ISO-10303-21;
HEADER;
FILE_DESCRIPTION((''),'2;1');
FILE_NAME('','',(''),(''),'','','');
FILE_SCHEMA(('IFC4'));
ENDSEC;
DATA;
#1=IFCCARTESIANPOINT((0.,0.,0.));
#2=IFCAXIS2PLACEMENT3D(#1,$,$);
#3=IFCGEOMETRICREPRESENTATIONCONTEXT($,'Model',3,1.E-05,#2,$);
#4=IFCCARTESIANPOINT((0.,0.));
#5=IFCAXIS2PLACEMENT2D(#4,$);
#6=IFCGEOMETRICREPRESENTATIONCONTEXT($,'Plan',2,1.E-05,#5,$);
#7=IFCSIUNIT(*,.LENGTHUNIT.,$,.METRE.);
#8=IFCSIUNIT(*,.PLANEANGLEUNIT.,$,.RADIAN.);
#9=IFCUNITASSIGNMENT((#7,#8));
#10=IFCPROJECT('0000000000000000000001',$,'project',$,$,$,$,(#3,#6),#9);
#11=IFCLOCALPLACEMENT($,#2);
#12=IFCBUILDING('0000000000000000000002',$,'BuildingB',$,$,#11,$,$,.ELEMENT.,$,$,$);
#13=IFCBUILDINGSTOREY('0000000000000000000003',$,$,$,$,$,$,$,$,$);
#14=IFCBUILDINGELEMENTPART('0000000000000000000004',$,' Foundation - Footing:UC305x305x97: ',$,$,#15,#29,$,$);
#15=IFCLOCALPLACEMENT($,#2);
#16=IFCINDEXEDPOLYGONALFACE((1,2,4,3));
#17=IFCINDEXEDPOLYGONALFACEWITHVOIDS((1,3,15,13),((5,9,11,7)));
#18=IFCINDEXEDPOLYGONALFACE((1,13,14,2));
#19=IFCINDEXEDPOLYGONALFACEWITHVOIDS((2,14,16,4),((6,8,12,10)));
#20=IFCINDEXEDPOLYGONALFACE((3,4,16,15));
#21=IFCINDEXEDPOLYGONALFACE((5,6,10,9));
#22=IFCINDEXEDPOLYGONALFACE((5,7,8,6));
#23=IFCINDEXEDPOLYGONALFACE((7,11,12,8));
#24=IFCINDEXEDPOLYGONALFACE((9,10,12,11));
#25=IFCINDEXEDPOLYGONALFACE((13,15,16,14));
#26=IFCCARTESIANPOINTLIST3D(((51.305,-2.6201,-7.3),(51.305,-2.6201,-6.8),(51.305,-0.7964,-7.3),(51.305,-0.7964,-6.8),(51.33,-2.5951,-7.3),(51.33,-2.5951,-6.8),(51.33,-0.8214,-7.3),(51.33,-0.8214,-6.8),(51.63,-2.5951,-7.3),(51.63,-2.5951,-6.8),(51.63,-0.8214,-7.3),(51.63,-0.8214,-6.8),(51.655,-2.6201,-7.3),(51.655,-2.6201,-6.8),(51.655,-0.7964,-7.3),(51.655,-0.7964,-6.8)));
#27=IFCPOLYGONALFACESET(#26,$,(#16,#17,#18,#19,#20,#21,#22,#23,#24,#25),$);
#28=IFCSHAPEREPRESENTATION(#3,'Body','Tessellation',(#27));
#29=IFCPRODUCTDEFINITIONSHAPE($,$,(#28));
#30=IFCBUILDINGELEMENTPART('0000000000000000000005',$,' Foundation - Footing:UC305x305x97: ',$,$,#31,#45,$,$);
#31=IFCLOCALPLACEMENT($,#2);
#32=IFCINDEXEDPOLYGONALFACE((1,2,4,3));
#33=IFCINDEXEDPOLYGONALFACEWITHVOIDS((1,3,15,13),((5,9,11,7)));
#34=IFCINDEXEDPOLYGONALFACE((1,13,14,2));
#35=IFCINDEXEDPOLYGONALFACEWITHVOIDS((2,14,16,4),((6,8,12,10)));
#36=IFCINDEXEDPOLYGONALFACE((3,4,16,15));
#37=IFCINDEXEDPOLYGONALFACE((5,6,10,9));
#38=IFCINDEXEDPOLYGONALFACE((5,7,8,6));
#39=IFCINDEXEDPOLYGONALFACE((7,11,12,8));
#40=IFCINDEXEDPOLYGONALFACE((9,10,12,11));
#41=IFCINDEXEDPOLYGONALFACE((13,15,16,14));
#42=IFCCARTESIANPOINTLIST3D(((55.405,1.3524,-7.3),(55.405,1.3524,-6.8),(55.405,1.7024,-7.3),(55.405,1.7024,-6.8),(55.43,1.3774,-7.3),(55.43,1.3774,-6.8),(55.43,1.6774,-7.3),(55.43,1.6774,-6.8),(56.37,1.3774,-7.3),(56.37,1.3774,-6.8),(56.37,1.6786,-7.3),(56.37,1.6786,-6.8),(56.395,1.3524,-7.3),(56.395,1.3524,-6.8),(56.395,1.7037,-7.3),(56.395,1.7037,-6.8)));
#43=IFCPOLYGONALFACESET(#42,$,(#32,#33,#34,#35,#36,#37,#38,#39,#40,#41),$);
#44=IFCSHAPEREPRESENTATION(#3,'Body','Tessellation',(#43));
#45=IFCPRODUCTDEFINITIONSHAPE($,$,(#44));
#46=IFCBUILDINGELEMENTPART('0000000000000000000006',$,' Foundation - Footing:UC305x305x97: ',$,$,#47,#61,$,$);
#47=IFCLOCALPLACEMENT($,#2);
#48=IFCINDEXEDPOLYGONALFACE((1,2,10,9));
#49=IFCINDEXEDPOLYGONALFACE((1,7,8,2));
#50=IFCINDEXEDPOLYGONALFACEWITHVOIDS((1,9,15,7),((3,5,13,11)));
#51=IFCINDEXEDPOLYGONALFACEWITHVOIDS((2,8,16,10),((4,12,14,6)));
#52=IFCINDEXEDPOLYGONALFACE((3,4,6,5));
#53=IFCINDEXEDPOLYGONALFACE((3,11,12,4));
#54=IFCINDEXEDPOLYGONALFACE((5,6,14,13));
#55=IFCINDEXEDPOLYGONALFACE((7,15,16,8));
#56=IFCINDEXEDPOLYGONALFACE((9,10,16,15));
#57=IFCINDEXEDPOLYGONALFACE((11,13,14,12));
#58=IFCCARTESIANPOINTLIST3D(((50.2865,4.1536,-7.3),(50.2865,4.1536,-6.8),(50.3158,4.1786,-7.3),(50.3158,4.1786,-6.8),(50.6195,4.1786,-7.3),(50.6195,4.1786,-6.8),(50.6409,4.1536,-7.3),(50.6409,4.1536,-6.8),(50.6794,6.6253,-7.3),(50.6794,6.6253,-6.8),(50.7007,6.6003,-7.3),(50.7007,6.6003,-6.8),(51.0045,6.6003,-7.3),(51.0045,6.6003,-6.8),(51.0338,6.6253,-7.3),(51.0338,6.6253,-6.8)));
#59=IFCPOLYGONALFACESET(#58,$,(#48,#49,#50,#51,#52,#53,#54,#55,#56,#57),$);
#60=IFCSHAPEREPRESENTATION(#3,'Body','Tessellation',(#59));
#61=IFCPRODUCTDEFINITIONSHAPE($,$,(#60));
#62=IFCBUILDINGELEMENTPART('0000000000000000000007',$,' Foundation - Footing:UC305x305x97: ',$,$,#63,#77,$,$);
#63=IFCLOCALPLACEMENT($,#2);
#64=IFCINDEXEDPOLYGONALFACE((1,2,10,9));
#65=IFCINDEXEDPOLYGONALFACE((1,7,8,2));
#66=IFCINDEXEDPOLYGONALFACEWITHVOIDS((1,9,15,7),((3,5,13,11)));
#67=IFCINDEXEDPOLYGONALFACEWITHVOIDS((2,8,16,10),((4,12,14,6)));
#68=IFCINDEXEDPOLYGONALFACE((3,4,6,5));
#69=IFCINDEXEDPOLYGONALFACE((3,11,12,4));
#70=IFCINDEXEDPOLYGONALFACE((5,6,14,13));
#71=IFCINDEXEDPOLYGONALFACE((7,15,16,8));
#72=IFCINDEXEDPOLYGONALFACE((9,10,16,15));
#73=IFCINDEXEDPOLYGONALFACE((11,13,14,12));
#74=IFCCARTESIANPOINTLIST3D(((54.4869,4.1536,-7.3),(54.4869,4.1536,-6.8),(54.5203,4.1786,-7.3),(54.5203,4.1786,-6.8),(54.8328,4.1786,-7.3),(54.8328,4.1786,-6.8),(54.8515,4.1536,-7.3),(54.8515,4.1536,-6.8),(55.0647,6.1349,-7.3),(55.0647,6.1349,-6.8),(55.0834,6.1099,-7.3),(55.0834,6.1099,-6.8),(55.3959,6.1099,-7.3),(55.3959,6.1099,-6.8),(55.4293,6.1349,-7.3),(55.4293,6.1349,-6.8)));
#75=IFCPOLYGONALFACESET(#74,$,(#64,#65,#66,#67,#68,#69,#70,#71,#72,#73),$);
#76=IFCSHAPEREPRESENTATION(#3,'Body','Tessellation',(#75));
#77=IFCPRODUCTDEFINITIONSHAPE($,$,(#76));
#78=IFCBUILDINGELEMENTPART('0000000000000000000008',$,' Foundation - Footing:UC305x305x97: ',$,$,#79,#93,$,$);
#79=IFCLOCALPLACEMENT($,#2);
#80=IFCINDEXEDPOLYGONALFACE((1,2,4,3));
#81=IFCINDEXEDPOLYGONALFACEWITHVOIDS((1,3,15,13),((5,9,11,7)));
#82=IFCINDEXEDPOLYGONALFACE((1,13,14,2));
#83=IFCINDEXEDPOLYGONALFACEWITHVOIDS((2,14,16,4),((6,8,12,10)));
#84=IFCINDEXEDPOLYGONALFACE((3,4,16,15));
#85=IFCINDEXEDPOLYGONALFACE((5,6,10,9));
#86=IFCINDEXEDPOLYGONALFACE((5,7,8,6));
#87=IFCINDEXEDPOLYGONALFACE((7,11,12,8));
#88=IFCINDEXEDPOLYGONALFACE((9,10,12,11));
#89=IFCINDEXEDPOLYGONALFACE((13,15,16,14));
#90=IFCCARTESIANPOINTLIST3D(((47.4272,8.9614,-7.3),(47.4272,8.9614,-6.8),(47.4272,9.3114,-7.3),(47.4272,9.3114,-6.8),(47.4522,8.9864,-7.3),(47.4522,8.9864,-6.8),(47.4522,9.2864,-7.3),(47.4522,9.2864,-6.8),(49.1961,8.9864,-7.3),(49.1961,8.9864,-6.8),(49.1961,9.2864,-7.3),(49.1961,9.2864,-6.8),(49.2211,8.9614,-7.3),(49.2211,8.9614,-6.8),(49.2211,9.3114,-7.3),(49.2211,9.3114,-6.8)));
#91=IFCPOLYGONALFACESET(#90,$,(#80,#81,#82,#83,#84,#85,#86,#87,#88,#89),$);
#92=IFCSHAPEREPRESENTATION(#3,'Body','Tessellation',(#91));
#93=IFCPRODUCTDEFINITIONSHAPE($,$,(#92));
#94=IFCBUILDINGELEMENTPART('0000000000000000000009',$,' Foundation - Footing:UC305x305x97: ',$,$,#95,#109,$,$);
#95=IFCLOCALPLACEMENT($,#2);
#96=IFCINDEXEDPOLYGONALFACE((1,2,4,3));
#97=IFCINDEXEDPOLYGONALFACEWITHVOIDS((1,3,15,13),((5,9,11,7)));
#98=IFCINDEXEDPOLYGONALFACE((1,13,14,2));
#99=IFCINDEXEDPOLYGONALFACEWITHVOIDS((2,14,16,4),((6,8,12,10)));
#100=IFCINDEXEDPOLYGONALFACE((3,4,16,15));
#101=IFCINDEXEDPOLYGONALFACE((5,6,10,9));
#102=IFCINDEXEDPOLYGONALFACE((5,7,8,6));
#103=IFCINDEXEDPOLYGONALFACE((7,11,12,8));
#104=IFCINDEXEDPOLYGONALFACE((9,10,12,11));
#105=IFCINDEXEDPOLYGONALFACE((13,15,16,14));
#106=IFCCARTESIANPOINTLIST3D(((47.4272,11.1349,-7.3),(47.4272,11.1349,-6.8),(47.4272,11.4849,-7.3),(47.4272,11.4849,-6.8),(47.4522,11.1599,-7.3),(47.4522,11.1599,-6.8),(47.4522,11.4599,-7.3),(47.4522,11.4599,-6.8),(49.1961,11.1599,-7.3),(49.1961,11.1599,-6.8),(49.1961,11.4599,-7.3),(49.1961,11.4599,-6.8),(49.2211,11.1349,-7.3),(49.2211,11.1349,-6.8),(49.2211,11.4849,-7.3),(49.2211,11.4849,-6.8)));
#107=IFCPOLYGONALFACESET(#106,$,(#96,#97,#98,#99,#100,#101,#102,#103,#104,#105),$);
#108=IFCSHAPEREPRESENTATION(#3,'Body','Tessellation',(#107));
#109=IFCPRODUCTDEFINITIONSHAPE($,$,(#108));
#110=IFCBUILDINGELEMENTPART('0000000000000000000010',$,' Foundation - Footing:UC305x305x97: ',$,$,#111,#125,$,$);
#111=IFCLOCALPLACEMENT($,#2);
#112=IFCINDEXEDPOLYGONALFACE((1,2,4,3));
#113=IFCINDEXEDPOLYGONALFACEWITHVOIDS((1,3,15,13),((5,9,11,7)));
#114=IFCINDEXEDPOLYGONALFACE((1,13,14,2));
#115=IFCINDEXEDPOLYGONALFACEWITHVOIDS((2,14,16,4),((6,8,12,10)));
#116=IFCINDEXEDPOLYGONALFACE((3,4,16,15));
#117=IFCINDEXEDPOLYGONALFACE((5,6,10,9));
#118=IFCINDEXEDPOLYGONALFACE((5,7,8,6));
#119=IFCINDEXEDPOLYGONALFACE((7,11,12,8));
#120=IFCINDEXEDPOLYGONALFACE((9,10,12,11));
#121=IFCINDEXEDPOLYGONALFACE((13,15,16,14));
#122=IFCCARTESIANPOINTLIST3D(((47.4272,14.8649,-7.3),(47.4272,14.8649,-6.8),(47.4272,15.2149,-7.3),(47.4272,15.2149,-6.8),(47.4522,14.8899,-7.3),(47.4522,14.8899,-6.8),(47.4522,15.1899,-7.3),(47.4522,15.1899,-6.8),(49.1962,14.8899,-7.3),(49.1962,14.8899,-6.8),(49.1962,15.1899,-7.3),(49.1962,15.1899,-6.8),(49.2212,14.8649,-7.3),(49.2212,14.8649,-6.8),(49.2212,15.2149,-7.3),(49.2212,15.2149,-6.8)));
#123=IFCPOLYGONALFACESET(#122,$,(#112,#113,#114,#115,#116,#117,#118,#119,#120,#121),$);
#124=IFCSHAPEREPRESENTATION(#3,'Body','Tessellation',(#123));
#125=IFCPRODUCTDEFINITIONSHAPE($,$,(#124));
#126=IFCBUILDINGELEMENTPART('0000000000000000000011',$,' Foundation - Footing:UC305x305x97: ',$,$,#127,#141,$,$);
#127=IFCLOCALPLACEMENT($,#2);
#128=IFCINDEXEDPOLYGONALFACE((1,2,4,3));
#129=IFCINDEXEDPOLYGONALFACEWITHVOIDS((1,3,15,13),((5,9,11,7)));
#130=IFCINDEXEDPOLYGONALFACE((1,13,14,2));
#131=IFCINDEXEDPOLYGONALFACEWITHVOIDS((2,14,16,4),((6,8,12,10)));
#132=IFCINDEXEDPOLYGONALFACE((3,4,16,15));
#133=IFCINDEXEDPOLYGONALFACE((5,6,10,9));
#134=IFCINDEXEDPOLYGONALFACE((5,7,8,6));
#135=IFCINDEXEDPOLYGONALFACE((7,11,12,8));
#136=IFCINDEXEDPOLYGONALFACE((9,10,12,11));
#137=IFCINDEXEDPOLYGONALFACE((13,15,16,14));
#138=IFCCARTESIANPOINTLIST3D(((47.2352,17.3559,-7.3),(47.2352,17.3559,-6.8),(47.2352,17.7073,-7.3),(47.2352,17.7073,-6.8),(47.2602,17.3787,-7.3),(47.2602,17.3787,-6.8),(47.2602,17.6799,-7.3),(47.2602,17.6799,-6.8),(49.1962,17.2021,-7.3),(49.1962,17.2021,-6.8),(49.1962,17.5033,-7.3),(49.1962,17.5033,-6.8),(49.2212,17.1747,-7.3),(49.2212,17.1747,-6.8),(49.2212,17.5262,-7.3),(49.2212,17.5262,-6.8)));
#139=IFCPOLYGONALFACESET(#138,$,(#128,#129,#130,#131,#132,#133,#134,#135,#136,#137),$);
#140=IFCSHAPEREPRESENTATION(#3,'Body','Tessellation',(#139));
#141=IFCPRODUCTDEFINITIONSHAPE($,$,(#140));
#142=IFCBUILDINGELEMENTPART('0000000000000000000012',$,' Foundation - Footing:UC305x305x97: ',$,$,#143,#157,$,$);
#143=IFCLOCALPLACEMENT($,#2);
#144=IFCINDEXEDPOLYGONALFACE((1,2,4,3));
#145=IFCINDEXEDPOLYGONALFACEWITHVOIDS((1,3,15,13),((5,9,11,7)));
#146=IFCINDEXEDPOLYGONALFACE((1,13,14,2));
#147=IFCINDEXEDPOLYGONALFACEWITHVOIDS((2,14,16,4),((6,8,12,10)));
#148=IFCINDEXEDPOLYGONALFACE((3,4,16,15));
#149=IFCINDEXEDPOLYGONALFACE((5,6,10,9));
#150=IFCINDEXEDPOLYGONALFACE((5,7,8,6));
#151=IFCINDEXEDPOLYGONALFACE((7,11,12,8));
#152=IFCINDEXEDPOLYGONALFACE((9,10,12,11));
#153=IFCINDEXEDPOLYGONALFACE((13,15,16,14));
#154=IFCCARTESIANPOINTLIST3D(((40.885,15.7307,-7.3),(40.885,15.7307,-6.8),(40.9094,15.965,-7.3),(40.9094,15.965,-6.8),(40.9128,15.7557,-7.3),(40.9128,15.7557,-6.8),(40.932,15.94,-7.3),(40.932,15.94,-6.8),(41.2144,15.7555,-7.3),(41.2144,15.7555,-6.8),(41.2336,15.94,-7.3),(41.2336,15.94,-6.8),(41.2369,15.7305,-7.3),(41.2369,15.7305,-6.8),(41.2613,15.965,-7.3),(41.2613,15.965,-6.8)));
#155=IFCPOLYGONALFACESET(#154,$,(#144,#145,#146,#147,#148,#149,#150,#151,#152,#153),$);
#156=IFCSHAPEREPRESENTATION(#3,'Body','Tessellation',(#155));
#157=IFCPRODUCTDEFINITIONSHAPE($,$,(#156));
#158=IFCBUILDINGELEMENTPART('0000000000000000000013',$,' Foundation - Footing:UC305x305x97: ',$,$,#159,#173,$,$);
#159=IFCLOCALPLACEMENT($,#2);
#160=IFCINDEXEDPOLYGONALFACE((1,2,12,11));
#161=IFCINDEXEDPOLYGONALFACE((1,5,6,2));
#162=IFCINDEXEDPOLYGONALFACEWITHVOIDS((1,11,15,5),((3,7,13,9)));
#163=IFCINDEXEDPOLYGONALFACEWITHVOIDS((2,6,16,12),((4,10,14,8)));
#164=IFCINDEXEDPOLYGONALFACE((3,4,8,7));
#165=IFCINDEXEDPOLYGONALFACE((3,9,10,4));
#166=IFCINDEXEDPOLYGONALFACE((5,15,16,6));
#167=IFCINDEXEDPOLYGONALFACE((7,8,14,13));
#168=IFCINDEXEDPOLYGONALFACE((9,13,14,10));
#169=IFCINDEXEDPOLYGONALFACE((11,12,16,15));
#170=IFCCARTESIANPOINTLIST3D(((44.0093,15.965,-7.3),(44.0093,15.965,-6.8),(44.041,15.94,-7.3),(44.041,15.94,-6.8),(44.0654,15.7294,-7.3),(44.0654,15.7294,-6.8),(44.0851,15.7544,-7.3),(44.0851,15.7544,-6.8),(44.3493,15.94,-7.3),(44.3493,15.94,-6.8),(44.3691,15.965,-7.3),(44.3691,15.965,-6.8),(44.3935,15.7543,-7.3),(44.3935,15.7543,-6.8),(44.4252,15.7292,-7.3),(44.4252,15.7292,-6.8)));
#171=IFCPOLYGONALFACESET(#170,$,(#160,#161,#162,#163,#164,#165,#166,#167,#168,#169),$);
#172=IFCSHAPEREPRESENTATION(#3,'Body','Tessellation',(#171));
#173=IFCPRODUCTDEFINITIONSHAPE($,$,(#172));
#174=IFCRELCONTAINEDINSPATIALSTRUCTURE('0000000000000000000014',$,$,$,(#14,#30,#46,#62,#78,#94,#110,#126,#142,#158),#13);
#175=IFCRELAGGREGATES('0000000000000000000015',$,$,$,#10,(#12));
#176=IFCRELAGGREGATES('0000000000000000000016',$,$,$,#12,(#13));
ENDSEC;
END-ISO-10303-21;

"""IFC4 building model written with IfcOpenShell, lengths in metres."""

from ifc_helpers import new_model, si_unit, origin, origin_2d, place, context, project, spatial, polyline, outline, extrude, element, save


model = new_model("IFC4")

# Units and contexts
model_context = context("Model", 3, precision=1e-05, world=origin())
plan_context = context("Plan", 2, precision=1e-05, world=origin_2d())
ifc_project = project(units=[si_unit("LENGTHUNIT", "METRE"), si_unit("PLANEANGLEUNIT", "RADIAN")], contexts=[model_context, plan_context])

# Building, storey
building_placement = place(None, origin())
building = spatial("IfcBuilding", under=ifc_project, at=building_placement, Name="BuildingB", CompositionType="ELEMENT")
storey = spatial("IfcBuildingStorey", under=building)

# Building element parts, openings
building_element_part_1 = element("IfcBuildingElementPart", 1, inside=storey, Name=" Foundation - Footing:UC305x305x97: ", context=model_context, shape_type="SweptSolid", body=[
    extrude(outline(polyline([(51.305, -2.6201, -7.3), (51.655, -2.6201, -7.3), (51.655, -0.7964, -7.3), (51.305, -0.7964, -7.3), (51.305, -2.6201, -7.3)])), None, (0.0, 0.0, 1.0), 0.5),
])
element("IfcOpeningElement", 2, inside=storey, cuts=building_element_part_1, context=model_context, shape_type="SweptSolid", body=[
    extrude(outline(polyline([(51.33, -2.5951, -7.3), (51.63, -2.5951, -7.3), (51.63, -0.8214, -7.3), (51.33, -0.8214, -7.3), (51.33, -2.5951, -7.3)])), None, (0.0, 0.0, 1.0), 0.5),
])
building_element_part_2 = element("IfcBuildingElementPart", 3, inside=storey, Name=" Foundation - Footing:UC305x305x97: ", context=model_context, shape_type="SweptSolid", body=[
    extrude(outline(polyline([(55.405, 1.3524, -7.3), (55.405, 1.7024, -7.3), (56.395, 1.7037, -7.3), (56.395, 1.3524, -7.3), (55.405, 1.3524, -7.3)])), None, (0.0, 0.0, 1.0), 0.5),
])
element("IfcOpeningElement", 4, inside=storey, cuts=building_element_part_2, context=model_context, shape_type="SweptSolid", body=[
    extrude(outline(polyline([(55.43, 1.3774, -7.3), (55.43, 1.6774, -7.3), (56.37, 1.6786, -7.3), (56.37, 1.3774, -7.3), (55.43, 1.3774, -7.3)])), None, (0.0, 0.0, 1.0), 0.5),
])
building_element_part_3 = element("IfcBuildingElementPart", 5, inside=storey, Name=" Foundation - Footing:UC305x305x97: ", context=model_context, shape_type="SweptSolid", body=[
    extrude(outline(polyline([(50.2865, 4.1536, -7.3), (50.6794, 6.6253, -7.3), (51.0338, 6.6253, -7.3), (50.6409, 4.1536, -7.3), (50.2865, 4.1536, -7.3)])), None, (0.0, 0.0, 1.0), 0.5),
])
element("IfcOpeningElement", 6, inside=storey, cuts=building_element_part_3, context=model_context, shape_type="SweptSolid", body=[
    extrude(outline(polyline([(50.3158, 4.1786, -7.3), (50.7007, 6.6003, -7.3), (51.0045, 6.6003, -7.3), (50.6195, 4.1786, -7.3), (50.3158, 4.1786, -7.3)])), None, (0.0, 0.0, 1.0), 0.5),
])
building_element_part_4 = element("IfcBuildingElementPart", 7, inside=storey, Name=" Foundation - Footing:UC305x305x97: ", context=model_context, shape_type="SweptSolid", body=[
    extrude(outline(polyline([(54.8515, 4.1536, -7.3), (54.4869, 4.1536, -7.3), (55.0647, 6.1349, -7.3), (55.4293, 6.1349, -7.3), (54.8515, 4.1536, -7.3)])), None, (0.0, 0.0, 1.0), 0.5),
])
element("IfcOpeningElement", 8, inside=storey, cuts=building_element_part_4, context=model_context, shape_type="SweptSolid", body=[
    extrude(outline(polyline([(54.8328, 4.1786, -7.3), (54.5203, 4.1786, -7.3), (55.0834, 6.1099, -7.3), (55.3959, 6.1099, -7.3), (54.8328, 4.1786, -7.3)])), None, (0.0, 0.0, 1.0), 0.5),
])
building_element_part_5 = element("IfcBuildingElementPart", 9, inside=storey, Name=" Foundation - Footing:UC305x305x97: ", context=model_context, shape_type="SweptSolid", body=[
    extrude(outline(polyline([(47.4272, 8.9614, -7.3), (49.2211, 8.9614, -7.3), (49.2211, 9.3114, -7.3), (47.4272, 9.3114, -7.3), (47.4272, 8.9614, -7.3)])), None, (0.0, 0.0, 1.0), 0.5),
])
element("IfcOpeningElement", 10, inside=storey, cuts=building_element_part_5, context=model_context, shape_type="SweptSolid", body=[
    extrude(outline(polyline([(47.4522, 8.9864, -7.3), (49.1961, 8.9864, -7.3), (49.1961, 9.2864, -7.3), (47.4522, 9.2864, -7.3), (47.4522, 8.9864, -7.3)])), None, (0.0, 0.0, 1.0), 0.5),
])
building_element_part_6 = element("IfcBuildingElementPart", 11, inside=storey, Name=" Foundation - Footing:UC305x305x97: ", context=model_context, shape_type="SweptSolid", body=[
    extrude(outline(polyline([(47.4272, 11.1349, -7.3), (47.4272, 11.4849, -7.3), (49.2211, 11.4849, -7.3), (49.2211, 11.1349, -7.3), (47.4272, 11.1349, -7.3)])), None, (0.0, 0.0, 1.0), 0.5),
])
element("IfcOpeningElement", 12, inside=storey, cuts=building_element_part_6, context=model_context, shape_type="SweptSolid", body=[
    extrude(outline(polyline([(47.4522, 11.1599, -7.3), (47.4522, 11.4599, -7.3), (49.1961, 11.4599, -7.3), (49.1961, 11.1599, -7.3), (47.4522, 11.1599, -7.3)])), None, (0.0, 0.0, 1.0), 0.5),
])
building_element_part_7 = element("IfcBuildingElementPart", 13, inside=storey, Name=" Foundation - Footing:UC305x305x97: ", context=model_context, shape_type="SweptSolid", body=[
    extrude(outline(polyline([(47.4272, 14.8649, -7.3), (47.4272, 15.2149, -7.3), (49.2212, 15.2149, -7.3), (49.2212, 14.8649, -7.3), (47.4272, 14.8649, -7.3)])), None, (0.0, 0.0, 1.0), 0.5),
])
element("IfcOpeningElement", 14, inside=storey, cuts=building_element_part_7, context=model_context, shape_type="SweptSolid", body=[
    extrude(outline(polyline([(47.4522, 14.8899, -7.3), (47.4522, 15.1899, -7.3), (49.1962, 15.1899, -7.3), (49.1962, 14.8899, -7.3), (47.4522, 14.8899, -7.3)])), None, (0.0, 0.0, 1.0), 0.5),
])
building_element_part_8 = element("IfcBuildingElementPart", 15, inside=storey, Name=" Foundation - Footing:UC305x305x97: ", context=model_context, shape_type="SweptSolid", body=[
    extrude(outline(polyline([(47.2352, 17.3559, -7.3), (47.2352, 17.7073, -7.3), (49.2212, 17.5262, -7.3), (49.2212, 17.1747, -7.3), (47.2352, 17.3559, -7.3)])), None, (0.0, 0.0, 1.0), 0.5),
])
element("IfcOpeningElement", 16, inside=storey, cuts=building_element_part_8, context=model_context, shape_type="SweptSolid", body=[
    extrude(outline(polyline([(47.2602, 17.3787, -7.3), (47.2602, 17.6799, -7.3), (49.1962, 17.5033, -7.3), (49.1962, 17.2021, -7.3), (47.2602, 17.3787, -7.3)])), None, (0.0, 0.0, 1.0), 0.5),
])
building_element_part_9 = element("IfcBuildingElementPart", 17, inside=storey, Name=" Foundation - Footing:UC305x305x97: ", context=model_context, shape_type="SweptSolid", body=[
    extrude(outline(polyline([(40.885, 15.7307, -7.3), (40.9094, 15.965, -7.3), (41.2613, 15.965, -7.3), (41.2369, 15.7305, -7.3), (40.885, 15.7307, -7.3)])), None, (0.0, 0.0, 1.0), 0.5),
])
element("IfcOpeningElement", 18, inside=storey, cuts=building_element_part_9, context=model_context, shape_type="SweptSolid", body=[
    extrude(outline(polyline([(40.9128, 15.7557, -7.3), (40.932, 15.94, -7.3), (41.2336, 15.94, -7.3), (41.2144, 15.7555, -7.3), (40.9128, 15.7557, -7.3)])), None, (0.0, 0.0, 1.0), 0.5),
])
building_element_part_10 = element("IfcBuildingElementPart", 19, inside=storey, Name=" Foundation - Footing:UC305x305x97: ", context=model_context, shape_type="SweptSolid", body=[
    extrude(outline(polyline([(44.0654, 15.7294, -7.3), (44.0093, 15.965, -7.3), (44.3691, 15.965, -7.3), (44.4252, 15.7292, -7.3), (44.0654, 15.7294, -7.3)])), None, (0.0, 0.0, 1.0), 0.5),
])
element("IfcOpeningElement", 20, inside=storey, cuts=building_element_part_10, context=model_context, shape_type="SweptSolid", body=[
    extrude(outline(polyline([(44.0851, 15.7544, -7.3), (44.041, 15.94, -7.3), (44.3493, 15.94, -7.3), (44.3935, 15.7543, -7.3), (44.0851, 15.7544, -7.3)])), None, (0.0, 0.0, 1.0), 0.5),
])

save(model, "model.ifc")
